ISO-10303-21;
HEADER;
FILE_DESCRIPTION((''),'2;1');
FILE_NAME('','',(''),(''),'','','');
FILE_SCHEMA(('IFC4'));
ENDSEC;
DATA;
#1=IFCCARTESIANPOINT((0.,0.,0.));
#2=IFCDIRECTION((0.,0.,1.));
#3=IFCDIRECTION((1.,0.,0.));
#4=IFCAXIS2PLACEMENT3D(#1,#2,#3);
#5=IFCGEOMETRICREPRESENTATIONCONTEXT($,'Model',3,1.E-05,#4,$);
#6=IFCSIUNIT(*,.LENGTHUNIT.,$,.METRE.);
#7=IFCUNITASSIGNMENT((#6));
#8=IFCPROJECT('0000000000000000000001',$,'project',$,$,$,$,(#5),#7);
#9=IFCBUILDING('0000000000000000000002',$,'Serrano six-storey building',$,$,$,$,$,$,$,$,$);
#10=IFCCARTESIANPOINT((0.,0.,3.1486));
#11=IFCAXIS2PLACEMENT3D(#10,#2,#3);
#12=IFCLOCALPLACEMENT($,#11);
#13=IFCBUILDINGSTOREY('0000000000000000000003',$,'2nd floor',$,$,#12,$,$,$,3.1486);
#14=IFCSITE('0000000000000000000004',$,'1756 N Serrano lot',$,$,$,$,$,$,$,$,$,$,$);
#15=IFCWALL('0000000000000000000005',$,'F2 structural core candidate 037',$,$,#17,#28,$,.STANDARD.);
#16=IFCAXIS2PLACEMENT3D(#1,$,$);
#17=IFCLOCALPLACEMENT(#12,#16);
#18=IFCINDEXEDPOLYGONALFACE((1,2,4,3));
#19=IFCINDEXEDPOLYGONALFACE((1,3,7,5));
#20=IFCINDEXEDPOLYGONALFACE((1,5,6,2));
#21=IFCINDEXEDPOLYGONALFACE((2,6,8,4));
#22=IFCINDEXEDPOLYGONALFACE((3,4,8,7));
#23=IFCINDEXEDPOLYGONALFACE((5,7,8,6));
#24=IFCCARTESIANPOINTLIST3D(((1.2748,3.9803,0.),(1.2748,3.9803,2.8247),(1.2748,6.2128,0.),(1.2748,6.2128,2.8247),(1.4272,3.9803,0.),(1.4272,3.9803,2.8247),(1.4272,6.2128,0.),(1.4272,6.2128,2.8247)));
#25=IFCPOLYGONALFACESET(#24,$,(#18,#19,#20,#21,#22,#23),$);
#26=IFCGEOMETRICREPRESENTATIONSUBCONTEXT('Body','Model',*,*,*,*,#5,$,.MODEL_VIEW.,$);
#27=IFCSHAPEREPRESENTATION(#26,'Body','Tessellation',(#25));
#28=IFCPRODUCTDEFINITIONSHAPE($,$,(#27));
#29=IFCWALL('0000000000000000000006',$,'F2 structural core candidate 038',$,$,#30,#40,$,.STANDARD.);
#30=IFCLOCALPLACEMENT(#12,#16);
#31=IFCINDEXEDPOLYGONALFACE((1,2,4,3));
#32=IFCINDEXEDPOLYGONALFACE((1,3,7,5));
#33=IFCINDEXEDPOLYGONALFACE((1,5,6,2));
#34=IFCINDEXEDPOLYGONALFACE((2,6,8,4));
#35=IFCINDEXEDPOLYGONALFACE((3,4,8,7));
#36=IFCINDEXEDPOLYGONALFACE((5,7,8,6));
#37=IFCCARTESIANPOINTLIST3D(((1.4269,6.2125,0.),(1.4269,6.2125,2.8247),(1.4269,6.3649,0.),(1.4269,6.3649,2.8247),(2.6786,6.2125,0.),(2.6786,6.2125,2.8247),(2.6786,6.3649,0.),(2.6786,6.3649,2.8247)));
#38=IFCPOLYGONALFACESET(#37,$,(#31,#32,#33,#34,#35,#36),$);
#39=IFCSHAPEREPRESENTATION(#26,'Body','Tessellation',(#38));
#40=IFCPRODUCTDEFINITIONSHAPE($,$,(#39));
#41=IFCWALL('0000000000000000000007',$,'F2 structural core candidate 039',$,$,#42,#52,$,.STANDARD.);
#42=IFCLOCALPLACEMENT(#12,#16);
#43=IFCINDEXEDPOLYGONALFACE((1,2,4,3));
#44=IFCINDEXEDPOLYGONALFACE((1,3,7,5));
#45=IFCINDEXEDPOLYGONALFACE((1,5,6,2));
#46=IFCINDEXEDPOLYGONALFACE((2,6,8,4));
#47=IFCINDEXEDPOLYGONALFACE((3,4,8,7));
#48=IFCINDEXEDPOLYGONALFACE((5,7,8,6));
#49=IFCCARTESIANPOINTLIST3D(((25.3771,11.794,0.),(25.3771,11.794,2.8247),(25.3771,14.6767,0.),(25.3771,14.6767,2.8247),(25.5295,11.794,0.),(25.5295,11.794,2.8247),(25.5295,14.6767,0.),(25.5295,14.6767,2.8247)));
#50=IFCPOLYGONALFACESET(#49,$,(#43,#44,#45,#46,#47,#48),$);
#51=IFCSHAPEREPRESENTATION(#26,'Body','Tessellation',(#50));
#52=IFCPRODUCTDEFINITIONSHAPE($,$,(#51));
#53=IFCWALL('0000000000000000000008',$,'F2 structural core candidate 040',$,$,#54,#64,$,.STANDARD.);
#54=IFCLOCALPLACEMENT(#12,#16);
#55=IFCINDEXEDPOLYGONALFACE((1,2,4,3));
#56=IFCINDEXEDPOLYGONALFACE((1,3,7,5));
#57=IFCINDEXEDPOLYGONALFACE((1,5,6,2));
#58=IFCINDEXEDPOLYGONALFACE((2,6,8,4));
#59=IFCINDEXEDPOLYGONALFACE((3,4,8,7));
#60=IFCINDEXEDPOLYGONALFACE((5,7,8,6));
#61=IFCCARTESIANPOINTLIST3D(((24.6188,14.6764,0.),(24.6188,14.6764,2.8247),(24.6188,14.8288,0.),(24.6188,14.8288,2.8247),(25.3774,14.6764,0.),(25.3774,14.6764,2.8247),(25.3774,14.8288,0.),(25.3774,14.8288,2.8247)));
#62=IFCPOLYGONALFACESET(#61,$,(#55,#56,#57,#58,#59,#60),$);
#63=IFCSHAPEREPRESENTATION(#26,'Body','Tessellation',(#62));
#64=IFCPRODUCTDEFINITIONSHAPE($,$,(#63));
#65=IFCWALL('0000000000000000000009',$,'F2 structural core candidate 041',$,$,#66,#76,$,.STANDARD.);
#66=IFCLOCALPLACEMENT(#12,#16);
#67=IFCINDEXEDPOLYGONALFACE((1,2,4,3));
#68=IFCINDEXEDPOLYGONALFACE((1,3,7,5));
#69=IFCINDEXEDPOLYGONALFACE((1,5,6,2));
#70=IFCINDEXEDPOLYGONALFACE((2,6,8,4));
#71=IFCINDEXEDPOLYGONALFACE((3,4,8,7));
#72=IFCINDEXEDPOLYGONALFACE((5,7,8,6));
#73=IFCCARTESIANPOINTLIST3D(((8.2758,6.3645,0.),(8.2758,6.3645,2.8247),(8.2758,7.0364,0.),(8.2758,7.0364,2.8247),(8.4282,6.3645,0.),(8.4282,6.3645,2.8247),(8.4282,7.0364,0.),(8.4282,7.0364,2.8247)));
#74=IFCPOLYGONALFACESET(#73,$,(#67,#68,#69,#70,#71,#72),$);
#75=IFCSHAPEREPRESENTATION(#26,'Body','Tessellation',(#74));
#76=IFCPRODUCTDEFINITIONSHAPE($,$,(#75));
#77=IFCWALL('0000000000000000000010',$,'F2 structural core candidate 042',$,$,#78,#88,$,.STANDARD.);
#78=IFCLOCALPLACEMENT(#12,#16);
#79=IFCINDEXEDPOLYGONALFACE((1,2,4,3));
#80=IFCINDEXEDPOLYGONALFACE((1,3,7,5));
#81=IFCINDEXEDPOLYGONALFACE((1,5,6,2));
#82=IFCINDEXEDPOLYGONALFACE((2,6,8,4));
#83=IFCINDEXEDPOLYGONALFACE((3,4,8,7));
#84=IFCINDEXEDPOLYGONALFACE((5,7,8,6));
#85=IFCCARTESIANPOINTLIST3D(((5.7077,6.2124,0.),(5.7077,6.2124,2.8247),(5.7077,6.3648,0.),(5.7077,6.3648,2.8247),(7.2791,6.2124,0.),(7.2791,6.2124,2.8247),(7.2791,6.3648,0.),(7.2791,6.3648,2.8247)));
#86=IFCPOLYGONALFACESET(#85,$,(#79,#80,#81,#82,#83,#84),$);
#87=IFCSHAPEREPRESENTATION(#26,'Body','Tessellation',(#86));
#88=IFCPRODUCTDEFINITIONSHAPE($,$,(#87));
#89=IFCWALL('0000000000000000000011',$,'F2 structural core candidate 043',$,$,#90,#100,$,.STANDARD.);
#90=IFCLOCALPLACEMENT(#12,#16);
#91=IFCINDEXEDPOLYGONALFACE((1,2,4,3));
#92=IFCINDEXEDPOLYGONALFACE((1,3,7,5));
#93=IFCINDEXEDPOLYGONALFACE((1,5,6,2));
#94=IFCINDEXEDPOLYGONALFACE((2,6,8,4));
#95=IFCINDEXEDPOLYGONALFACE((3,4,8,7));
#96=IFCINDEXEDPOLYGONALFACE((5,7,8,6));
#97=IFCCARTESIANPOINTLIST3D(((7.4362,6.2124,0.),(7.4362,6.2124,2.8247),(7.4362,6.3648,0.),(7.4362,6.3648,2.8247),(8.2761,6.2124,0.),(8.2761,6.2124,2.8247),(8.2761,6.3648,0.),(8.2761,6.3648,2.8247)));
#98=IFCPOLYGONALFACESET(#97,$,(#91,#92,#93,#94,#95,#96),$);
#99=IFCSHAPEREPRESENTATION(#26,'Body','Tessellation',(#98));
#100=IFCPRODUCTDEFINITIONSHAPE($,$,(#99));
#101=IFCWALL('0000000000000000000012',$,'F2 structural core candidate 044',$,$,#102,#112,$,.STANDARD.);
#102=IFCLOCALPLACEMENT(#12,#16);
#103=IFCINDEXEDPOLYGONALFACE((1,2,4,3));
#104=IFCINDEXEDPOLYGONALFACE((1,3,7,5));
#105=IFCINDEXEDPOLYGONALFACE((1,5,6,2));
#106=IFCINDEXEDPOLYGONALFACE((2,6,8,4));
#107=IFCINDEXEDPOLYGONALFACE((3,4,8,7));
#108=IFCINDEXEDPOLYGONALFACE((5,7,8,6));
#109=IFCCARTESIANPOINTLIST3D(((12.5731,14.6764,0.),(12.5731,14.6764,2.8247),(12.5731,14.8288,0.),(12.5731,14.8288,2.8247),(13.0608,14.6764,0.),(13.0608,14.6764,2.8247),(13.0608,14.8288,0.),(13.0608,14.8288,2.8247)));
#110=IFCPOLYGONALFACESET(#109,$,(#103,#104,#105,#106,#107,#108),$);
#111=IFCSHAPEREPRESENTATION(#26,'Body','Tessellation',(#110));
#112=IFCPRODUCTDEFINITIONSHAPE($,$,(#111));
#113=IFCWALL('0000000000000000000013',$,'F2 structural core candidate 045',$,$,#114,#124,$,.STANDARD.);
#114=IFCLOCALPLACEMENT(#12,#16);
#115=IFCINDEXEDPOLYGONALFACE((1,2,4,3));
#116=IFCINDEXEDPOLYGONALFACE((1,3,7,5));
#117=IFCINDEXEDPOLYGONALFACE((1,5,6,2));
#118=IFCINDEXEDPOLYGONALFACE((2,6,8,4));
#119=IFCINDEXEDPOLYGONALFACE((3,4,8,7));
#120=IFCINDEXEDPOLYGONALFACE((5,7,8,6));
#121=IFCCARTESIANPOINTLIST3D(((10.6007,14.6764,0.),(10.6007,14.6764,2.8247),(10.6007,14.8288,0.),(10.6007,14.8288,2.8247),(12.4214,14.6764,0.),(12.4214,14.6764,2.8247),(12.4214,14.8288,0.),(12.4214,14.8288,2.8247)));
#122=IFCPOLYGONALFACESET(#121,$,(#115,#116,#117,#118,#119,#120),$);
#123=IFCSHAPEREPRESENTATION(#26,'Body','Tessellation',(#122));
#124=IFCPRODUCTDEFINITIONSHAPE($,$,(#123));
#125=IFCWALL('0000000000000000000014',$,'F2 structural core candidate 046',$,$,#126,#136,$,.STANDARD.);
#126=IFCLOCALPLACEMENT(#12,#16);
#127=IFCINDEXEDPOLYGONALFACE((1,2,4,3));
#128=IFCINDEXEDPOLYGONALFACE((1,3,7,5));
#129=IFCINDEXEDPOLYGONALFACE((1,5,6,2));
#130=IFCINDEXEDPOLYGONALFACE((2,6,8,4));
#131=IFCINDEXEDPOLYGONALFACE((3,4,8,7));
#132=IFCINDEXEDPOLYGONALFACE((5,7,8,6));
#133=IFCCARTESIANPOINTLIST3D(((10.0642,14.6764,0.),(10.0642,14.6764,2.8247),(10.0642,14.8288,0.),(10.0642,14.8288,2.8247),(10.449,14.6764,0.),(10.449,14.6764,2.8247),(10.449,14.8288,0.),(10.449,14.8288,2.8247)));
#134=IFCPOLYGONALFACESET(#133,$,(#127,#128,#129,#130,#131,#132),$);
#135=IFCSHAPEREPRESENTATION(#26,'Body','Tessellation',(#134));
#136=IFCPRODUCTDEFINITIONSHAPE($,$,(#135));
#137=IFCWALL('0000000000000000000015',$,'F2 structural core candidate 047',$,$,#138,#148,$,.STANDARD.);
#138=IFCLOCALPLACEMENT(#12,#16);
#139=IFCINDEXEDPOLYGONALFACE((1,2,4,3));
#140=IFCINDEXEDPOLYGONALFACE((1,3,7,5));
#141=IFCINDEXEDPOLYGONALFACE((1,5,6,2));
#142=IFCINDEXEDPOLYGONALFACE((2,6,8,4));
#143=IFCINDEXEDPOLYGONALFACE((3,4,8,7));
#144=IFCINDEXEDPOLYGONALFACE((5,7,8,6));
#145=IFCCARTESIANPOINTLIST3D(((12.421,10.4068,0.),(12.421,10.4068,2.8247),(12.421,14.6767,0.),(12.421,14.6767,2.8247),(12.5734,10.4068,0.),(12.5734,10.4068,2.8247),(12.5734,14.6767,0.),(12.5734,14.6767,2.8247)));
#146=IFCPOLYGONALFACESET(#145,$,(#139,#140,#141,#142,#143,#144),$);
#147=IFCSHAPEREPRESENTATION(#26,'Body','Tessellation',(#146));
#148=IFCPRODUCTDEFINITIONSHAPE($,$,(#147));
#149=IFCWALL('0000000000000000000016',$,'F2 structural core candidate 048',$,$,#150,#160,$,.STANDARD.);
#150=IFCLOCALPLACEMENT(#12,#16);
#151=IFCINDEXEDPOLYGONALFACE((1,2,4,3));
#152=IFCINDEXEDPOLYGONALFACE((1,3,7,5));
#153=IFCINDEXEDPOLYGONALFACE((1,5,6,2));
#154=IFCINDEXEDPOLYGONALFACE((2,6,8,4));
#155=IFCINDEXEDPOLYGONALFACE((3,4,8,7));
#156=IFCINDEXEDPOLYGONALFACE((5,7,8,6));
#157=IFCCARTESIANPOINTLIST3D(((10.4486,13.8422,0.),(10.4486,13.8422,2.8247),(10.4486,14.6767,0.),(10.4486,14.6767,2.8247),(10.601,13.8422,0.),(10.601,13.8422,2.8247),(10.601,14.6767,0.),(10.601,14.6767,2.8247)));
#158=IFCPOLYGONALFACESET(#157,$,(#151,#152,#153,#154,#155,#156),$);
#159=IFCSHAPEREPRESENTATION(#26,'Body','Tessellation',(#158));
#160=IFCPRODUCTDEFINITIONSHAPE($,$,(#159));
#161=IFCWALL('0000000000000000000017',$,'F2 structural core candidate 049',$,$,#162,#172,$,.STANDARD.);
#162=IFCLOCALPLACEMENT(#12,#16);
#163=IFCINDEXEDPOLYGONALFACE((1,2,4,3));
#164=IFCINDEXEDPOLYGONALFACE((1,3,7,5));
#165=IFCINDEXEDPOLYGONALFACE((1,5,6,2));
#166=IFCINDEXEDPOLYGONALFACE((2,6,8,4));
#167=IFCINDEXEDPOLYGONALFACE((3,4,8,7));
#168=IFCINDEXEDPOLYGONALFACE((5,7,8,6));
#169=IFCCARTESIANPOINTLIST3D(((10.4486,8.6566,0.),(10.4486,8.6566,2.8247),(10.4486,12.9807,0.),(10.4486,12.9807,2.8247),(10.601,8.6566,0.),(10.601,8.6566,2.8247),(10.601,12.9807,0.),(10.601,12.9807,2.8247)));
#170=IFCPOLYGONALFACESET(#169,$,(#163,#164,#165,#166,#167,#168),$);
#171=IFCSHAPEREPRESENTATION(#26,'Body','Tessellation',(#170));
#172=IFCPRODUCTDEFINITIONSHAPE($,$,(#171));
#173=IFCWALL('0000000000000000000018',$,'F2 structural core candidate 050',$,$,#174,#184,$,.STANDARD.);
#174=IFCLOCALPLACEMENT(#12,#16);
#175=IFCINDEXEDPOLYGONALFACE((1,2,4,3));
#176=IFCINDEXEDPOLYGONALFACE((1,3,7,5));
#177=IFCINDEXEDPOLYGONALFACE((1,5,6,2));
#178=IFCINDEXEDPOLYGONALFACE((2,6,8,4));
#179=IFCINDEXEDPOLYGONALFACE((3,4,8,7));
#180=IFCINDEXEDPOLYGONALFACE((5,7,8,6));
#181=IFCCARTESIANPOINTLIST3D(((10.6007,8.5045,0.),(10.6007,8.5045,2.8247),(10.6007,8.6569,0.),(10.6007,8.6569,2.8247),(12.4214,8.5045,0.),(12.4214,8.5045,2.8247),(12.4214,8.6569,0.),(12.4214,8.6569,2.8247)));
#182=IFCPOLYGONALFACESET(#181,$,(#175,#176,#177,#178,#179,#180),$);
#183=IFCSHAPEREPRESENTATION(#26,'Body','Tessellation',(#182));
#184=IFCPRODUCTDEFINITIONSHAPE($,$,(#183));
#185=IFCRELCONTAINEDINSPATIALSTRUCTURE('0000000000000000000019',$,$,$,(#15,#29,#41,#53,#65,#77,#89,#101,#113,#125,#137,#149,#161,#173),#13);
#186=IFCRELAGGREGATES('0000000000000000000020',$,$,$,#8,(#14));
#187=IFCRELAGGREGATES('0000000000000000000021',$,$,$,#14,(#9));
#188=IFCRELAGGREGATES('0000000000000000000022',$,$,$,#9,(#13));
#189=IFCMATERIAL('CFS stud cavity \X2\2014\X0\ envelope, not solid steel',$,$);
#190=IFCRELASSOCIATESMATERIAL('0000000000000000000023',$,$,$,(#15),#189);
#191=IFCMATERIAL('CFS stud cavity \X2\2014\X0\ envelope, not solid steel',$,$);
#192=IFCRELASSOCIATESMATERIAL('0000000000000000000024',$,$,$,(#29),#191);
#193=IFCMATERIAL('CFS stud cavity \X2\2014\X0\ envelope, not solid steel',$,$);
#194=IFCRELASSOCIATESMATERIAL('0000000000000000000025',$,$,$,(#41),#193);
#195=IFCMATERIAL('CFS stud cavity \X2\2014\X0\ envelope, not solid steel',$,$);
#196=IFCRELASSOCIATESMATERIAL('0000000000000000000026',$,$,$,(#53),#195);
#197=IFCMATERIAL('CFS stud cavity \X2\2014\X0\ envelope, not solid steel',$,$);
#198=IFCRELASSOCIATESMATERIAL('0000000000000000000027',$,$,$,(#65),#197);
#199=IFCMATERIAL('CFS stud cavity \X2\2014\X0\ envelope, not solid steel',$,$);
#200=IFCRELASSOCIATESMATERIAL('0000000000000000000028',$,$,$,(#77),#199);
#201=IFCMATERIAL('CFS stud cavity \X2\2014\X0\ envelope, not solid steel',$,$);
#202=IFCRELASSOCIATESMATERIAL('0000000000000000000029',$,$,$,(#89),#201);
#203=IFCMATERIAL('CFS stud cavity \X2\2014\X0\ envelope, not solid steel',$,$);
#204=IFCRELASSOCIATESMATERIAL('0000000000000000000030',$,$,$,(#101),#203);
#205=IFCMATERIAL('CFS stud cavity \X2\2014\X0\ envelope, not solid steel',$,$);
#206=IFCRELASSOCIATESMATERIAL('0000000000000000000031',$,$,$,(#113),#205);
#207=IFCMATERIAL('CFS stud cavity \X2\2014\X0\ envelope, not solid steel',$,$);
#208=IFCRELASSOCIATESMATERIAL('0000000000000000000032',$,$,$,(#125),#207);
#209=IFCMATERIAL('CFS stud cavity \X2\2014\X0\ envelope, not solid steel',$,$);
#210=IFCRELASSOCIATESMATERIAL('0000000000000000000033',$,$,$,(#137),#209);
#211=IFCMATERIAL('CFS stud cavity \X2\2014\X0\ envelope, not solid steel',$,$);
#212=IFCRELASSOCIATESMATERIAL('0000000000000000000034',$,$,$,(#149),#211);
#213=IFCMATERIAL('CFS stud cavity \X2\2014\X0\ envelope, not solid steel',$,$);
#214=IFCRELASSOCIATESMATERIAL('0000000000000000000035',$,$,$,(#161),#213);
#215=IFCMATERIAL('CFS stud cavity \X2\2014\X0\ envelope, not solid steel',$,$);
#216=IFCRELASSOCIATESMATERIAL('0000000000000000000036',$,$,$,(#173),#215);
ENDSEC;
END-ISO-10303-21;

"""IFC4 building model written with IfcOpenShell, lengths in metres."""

from ifc_helpers import new_model, si_unit, frame, origin_with_axes, place, context, subcontext, project, spatial, polyline, outline, extrude, material, element, save


model = new_model("IFC4")

# Units and contexts
model_context = context("Model", 3, precision=1e-05, world=origin_with_axes())
body_context = subcontext(model_context, "Body", "Model", "MODEL_VIEW")
ifc_project = project(units=[si_unit("LENGTHUNIT", "METRE")], contexts=[model_context])

# Site, building, storey
site = spatial("IfcSite", under=ifc_project, Name="1756 N Serrano lot")
building = spatial("IfcBuilding", under=site, Name="Serrano six-storey building")
storey_placement = place(None, frame((0.0, 0.0, 3.1486), z_axis=(0.0, 0.0, 1.0), x_axis=(1.0, 0.0, 0.0)))
storey = spatial("IfcBuildingStorey", under=building, at=storey_placement, Name="2nd floor", Elevation=3.1486)

# Walls
ifc_material_1 = material(Name="CFS stud cavity — envelope, not solid steel")
wall_1_placement = place(storey_placement, frame((0.0, 0.0, -3.1486), z_axis=(0.0, 0.0, 1.0), x_axis=(1.0, 0.0, 0.0)))
element("IfcWall", 1, at=wall_1_placement, inside=storey, material=ifc_material_1, Name="F2 structural core candidate 037", PredefinedType="STANDARD", context=body_context, shape_type="SweptSolid", body=[
    extrude(outline(polyline([(1.4272, 3.9803), (1.2748, 3.9803), (1.2748, 6.2128), (1.4272, 6.2128), (1.4272, 3.9803)])), frame((0.0, 0.0, 3.1486)), (0.0, 0.0, 1.0), 2.8247),
])
ifc_material_2 = material(Name="CFS stud cavity — envelope, not solid steel")
wall_2_placement = place(storey_placement, frame((0.0, 0.0, -3.1486), z_axis=(0.0, 0.0, 1.0), x_axis=(1.0, 0.0, 0.0)))
element("IfcWall", 2, at=wall_2_placement, inside=storey, material=ifc_material_2, Name="F2 structural core candidate 038", PredefinedType="STANDARD", context=body_context, shape_type="SweptSolid", body=[
    extrude(outline(polyline([(2.6786, 6.3649), (2.6786, 6.2125), (1.4269, 6.2125), (1.4269, 6.3649), (2.6786, 6.3649)])), frame((0.0, 0.0, 3.1486)), (0.0, 0.0, 1.0), 2.8247),
])
ifc_material_3 = material(Name="CFS stud cavity — envelope, not solid steel")
wall_3_placement = place(storey_placement, frame((0.0, 0.0, -3.1486), z_axis=(0.0, 0.0, 1.0), x_axis=(1.0, 0.0, 0.0)))
element("IfcWall", 3, at=wall_3_placement, inside=storey, material=ifc_material_3, Name="F2 structural core candidate 039", PredefinedType="STANDARD", context=body_context, shape_type="SweptSolid", body=[
    extrude(outline(polyline([(25.5295, 11.794), (25.3771, 11.794), (25.3771, 14.6767), (25.5295, 14.6767), (25.5295, 11.794)])), frame((0.0, 0.0, 3.1486)), (0.0, 0.0, 1.0), 2.8247),
])
ifc_material_4 = material(Name="CFS stud cavity — envelope, not solid steel")
wall_4_placement = place(storey_placement, frame((0.0, 0.0, -3.1486), z_axis=(0.0, 0.0, 1.0), x_axis=(1.0, 0.0, 0.0)))
element("IfcWall", 4, at=wall_4_placement, inside=storey, material=ifc_material_4, Name="F2 structural core candidate 040", PredefinedType="STANDARD", context=body_context, shape_type="SweptSolid", body=[
    extrude(outline(polyline([(25.3774, 14.8288), (25.3774, 14.6764), (24.6188, 14.6764), (24.6188, 14.8288), (25.3774, 14.8288)])), frame((0.0, 0.0, 3.1486)), (0.0, 0.0, 1.0), 2.8247),
])
ifc_material_5 = material(Name="CFS stud cavity — envelope, not solid steel")
wall_5_placement = place(storey_placement, frame((0.0, 0.0, -3.1486), z_axis=(0.0, 0.0, 1.0), x_axis=(1.0, 0.0, 0.0)))
element("IfcWall", 5, at=wall_5_placement, inside=storey, material=ifc_material_5, Name="F2 structural core candidate 041", PredefinedType="STANDARD", context=body_context, shape_type="SweptSolid", body=[
    extrude(outline(polyline([(8.4282, 6.3645), (8.2758, 6.3645), (8.2758, 7.0364), (8.4282, 7.0364), (8.4282, 6.3645)])), frame((0.0, 0.0, 3.1486)), (0.0, 0.0, 1.0), 2.8247),
])
ifc_material_6 = material(Name="CFS stud cavity — envelope, not solid steel")
wall_6_placement = place(storey_placement, frame((0.0, 0.0, -3.1486), z_axis=(0.0, 0.0, 1.0), x_axis=(1.0, 0.0, 0.0)))
element("IfcWall", 6, at=wall_6_placement, inside=storey, material=ifc_material_6, Name="F2 structural core candidate 042", PredefinedType="STANDARD", context=body_context, shape_type="SweptSolid", body=[
    extrude(outline(polyline([(7.2791, 6.3648), (7.2791, 6.2124), (5.7077, 6.2124), (5.7077, 6.3648), (7.2791, 6.3648)])), frame((0.0, 0.0, 3.1486)), (0.0, 0.0, 1.0), 2.8247),
])
ifc_material_7 = material(Name="CFS stud cavity — envelope, not solid steel")
wall_7_placement = place(storey_placement, frame((0.0, 0.0, -3.1486), z_axis=(0.0, 0.0, 1.0), x_axis=(1.0, 0.0, 0.0)))
element("IfcWall", 7, at=wall_7_placement, inside=storey, material=ifc_material_7, Name="F2 structural core candidate 043", PredefinedType="STANDARD", context=body_context, shape_type="SweptSolid", body=[
    extrude(outline(polyline([(8.2761, 6.3648), (8.2761, 6.2124), (7.4362, 6.2124), (7.4362, 6.3648), (8.2761, 6.3648)])), frame((0.0, 0.0, 3.1486)), (0.0, 0.0, 1.0), 2.8247),
])
ifc_material_8 = material(Name="CFS stud cavity — envelope, not solid steel")
wall_8_placement = place(storey_placement, frame((0.0, 0.0, -3.1486), z_axis=(0.0, 0.0, 1.0), x_axis=(1.0, 0.0, 0.0)))
element("IfcWall", 8, at=wall_8_placement, inside=storey, material=ifc_material_8, Name="F2 structural core candidate 044", PredefinedType="STANDARD", context=body_context, shape_type="SweptSolid", body=[
    extrude(outline(polyline([(13.0608, 14.8288), (13.0608, 14.6764), (12.5731, 14.6764), (12.5731, 14.8288), (13.0608, 14.8288)])), frame((0.0, 0.0, 3.1486)), (0.0, 0.0, 1.0), 2.8247),
])
ifc_material_9 = material(Name="CFS stud cavity — envelope, not solid steel")
wall_9_placement = place(storey_placement, frame((0.0, 0.0, -3.1486), z_axis=(0.0, 0.0, 1.0), x_axis=(1.0, 0.0, 0.0)))
element("IfcWall", 9, at=wall_9_placement, inside=storey, material=ifc_material_9, Name="F2 structural core candidate 045", PredefinedType="STANDARD", context=body_context, shape_type="SweptSolid", body=[
    extrude(outline(polyline([(12.4214, 14.8288), (12.4214, 14.6764), (10.6007, 14.6764), (10.6007, 14.8288), (12.4214, 14.8288)])), frame((0.0, 0.0, 3.1486)), (0.0, 0.0, 1.0), 2.8247),
])
ifc_material_10 = material(Name="CFS stud cavity — envelope, not solid steel")
wall_10_placement = place(storey_placement, frame((0.0, 0.0, -3.1486), z_axis=(0.0, 0.0, 1.0), x_axis=(1.0, 0.0, 0.0)))
element("IfcWall", 10, at=wall_10_placement, inside=storey, material=ifc_material_10, Name="F2 structural core candidate 046", PredefinedType="STANDARD", context=body_context, shape_type="SweptSolid", body=[
    extrude(outline(polyline([(10.449, 14.8288), (10.449, 14.6764), (10.0642, 14.6764), (10.0642, 14.8288), (10.449, 14.8288)])), frame((0.0, 0.0, 3.1486)), (0.0, 0.0, 1.0), 2.8247),
])
ifc_material_11 = material(Name="CFS stud cavity — envelope, not solid steel")
wall_11_placement = place(storey_placement, frame((0.0, 0.0, -3.1486), z_axis=(0.0, 0.0, 1.0), x_axis=(1.0, 0.0, 0.0)))
element("IfcWall", 11, at=wall_11_placement, inside=storey, material=ifc_material_11, Name="F2 structural core candidate 047", PredefinedType="STANDARD", context=body_context, shape_type="SweptSolid", body=[
    extrude(outline(polyline([(12.5734, 10.4068), (12.421, 10.4068), (12.421, 14.6767), (12.5734, 14.6767), (12.5734, 10.4068)])), frame((0.0, 0.0, 3.1486)), (0.0, 0.0, 1.0), 2.8247),
])
ifc_material_12 = material(Name="CFS stud cavity — envelope, not solid steel")
wall_12_placement = place(storey_placement, frame((0.0, 0.0, -3.1486), z_axis=(0.0, 0.0, 1.0), x_axis=(1.0, 0.0, 0.0)))
element("IfcWall", 12, at=wall_12_placement, inside=storey, material=ifc_material_12, Name="F2 structural core candidate 048", PredefinedType="STANDARD", context=body_context, shape_type="SweptSolid", body=[
    extrude(outline(polyline([(10.601, 13.8422), (10.4486, 13.8422), (10.4486, 14.6767), (10.601, 14.6767), (10.601, 13.8422)])), frame((0.0, 0.0, 3.1486)), (0.0, 0.0, 1.0), 2.8247),
])
ifc_material_13 = material(Name="CFS stud cavity — envelope, not solid steel")
wall_13_placement = place(storey_placement, frame((0.0, 0.0, -3.1486), z_axis=(0.0, 0.0, 1.0), x_axis=(1.0, 0.0, 0.0)))
element("IfcWall", 13, at=wall_13_placement, inside=storey, material=ifc_material_13, Name="F2 structural core candidate 049", PredefinedType="STANDARD", context=body_context, shape_type="SweptSolid", body=[
    extrude(outline(polyline([(10.601, 8.6566), (10.4486, 8.6566), (10.4486, 12.9807), (10.601, 12.9807), (10.601, 8.6566)])), frame((0.0, 0.0, 3.1486)), (0.0, 0.0, 1.0), 2.8247),
])
ifc_material_14 = material(Name="CFS stud cavity — envelope, not solid steel")
wall_14_placement = place(storey_placement, frame((0.0, 0.0, -3.1486), z_axis=(0.0, 0.0, 1.0), x_axis=(1.0, 0.0, 0.0)))
element("IfcWall", 14, at=wall_14_placement, inside=storey, material=ifc_material_14, Name="F2 structural core candidate 050", PredefinedType="STANDARD", context=body_context, shape_type="SweptSolid", body=[
    extrude(outline(polyline([(12.4214, 8.6569), (12.4214, 8.5045), (10.6007, 8.5045), (10.6007, 8.6569), (12.4214, 8.6569)])), frame((0.0, 0.0, 3.1486)), (0.0, 0.0, 1.0), 2.8247),
])

save(model, "model.ifc")
